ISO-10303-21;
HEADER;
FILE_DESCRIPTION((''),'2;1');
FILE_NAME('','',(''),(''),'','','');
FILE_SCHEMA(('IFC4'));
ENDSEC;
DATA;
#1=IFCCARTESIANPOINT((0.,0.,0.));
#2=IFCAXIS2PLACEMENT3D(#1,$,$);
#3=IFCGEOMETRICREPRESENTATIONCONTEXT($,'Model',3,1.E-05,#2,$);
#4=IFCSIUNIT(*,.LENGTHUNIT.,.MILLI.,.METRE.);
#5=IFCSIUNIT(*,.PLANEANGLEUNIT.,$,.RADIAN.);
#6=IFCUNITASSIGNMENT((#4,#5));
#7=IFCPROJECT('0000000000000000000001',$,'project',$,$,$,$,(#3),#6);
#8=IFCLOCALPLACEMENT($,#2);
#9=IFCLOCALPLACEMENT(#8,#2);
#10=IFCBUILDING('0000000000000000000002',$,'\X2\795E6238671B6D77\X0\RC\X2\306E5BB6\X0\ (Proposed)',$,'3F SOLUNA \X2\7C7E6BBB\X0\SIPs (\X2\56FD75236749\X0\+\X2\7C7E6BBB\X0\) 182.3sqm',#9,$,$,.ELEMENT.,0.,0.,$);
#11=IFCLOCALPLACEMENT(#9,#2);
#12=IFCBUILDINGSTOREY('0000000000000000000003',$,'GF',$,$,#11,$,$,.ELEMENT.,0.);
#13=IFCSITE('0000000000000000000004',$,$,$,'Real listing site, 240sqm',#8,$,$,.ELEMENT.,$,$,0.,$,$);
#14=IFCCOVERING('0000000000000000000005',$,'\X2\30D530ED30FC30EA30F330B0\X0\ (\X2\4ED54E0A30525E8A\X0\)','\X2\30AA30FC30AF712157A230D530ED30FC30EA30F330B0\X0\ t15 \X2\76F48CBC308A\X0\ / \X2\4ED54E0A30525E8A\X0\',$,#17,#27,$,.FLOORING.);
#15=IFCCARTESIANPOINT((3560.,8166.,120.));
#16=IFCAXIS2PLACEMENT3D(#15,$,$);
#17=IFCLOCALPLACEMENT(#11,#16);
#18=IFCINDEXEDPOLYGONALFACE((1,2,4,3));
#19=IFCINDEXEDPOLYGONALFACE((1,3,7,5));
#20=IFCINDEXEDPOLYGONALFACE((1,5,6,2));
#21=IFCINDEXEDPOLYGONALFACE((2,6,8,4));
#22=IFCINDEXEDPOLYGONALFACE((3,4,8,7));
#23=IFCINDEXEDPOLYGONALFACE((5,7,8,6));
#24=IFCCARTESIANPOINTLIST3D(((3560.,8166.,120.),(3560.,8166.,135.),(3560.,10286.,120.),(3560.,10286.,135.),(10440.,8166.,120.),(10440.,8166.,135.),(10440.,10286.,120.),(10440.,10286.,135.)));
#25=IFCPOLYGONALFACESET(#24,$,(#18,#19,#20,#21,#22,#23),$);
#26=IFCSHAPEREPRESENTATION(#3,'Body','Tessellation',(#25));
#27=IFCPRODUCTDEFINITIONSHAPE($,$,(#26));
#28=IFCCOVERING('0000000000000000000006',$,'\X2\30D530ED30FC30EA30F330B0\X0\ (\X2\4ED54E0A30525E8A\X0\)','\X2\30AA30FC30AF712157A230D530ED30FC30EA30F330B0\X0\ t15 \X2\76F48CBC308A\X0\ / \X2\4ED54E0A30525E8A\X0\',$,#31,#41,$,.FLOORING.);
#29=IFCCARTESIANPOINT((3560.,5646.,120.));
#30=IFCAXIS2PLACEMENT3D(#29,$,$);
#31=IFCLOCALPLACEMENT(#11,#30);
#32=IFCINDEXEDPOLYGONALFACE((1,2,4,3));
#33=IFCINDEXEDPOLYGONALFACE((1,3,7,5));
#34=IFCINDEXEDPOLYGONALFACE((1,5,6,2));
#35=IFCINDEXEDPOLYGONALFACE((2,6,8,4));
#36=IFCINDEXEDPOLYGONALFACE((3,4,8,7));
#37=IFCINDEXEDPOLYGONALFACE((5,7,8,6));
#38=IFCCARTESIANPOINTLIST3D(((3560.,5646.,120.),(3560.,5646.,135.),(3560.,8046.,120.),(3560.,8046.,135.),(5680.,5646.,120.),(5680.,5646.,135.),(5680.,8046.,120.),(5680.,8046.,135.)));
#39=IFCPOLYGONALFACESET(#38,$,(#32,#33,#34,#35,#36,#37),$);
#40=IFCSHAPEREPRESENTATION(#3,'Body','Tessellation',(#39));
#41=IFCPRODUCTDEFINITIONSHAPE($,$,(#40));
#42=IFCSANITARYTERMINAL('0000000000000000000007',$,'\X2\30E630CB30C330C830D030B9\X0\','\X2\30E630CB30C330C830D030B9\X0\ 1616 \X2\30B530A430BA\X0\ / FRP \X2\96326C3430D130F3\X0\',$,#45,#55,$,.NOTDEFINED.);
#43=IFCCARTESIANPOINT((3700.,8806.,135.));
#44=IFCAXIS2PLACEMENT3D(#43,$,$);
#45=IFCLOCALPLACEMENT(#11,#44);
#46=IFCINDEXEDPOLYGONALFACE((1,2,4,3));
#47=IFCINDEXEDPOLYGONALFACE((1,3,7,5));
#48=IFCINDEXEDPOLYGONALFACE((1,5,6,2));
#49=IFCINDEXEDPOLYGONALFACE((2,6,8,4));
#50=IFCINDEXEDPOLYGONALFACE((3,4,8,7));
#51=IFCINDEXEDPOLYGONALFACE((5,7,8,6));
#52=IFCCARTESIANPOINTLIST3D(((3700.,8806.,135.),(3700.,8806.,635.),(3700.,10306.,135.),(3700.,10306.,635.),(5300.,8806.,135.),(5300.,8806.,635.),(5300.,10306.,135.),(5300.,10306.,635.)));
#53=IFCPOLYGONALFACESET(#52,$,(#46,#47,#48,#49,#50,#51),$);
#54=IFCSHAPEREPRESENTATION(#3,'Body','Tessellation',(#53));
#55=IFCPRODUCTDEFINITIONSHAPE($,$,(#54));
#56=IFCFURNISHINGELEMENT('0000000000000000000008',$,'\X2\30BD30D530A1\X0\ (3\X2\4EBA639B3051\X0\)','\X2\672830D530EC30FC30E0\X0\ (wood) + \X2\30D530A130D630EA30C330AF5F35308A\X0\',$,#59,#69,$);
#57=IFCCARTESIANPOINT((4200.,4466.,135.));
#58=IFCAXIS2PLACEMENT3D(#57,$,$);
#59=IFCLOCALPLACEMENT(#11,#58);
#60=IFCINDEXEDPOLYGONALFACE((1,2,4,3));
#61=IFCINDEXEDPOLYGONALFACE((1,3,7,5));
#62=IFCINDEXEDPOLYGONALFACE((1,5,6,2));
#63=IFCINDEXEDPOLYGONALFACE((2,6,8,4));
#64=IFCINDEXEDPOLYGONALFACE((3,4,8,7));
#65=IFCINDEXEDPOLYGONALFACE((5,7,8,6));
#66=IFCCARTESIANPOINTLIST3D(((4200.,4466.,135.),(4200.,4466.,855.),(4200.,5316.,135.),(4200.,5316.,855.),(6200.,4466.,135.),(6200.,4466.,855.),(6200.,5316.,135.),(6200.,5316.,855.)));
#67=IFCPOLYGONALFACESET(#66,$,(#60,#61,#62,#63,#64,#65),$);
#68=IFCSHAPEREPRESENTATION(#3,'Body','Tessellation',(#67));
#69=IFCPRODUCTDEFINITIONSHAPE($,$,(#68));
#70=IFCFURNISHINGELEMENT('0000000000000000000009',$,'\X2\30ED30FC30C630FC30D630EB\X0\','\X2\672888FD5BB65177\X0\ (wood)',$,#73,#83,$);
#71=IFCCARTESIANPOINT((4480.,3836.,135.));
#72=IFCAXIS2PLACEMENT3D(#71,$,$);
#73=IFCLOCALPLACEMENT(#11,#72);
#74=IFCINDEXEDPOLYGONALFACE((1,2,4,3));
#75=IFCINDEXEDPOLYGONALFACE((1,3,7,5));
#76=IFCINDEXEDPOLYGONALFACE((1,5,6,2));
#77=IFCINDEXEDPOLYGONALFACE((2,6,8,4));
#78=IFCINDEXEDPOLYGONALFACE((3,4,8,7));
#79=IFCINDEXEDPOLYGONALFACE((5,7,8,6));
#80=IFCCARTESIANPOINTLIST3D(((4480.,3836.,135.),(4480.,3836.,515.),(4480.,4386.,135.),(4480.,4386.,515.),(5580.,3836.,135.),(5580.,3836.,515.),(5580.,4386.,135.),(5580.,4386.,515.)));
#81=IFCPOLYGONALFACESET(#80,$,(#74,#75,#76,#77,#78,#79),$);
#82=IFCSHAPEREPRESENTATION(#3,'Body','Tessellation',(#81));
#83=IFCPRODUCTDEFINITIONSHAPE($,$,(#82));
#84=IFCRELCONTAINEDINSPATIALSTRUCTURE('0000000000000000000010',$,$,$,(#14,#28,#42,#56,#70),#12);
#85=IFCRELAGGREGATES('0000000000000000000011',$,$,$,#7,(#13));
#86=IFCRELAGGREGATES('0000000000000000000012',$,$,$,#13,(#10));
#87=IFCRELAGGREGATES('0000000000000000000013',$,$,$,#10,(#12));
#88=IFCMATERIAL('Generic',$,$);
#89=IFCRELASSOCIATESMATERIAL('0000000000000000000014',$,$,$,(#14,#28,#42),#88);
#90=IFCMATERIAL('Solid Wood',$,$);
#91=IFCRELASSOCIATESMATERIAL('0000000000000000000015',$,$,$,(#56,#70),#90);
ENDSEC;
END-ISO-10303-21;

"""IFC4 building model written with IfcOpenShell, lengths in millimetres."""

from ifc_helpers import new_model, si_unit, frame, frame_2d, origin, place, context, project, spatial, rectangle, extrude, material, element, save


model = new_model("IFC4")

# Units and contexts
model_context = context("Model", 3, precision=1e-05, world=origin())
ifc_project = project(units=[si_unit("LENGTHUNIT", "METRE", prefix="MILLI"), si_unit("PLANEANGLEUNIT", "RADIAN")], contexts=[model_context])

# Site, building, storey
site_placement = place(None, origin())
site = spatial("IfcSite", under=ifc_project, at=site_placement, ObjectType="Real listing site, 240sqm", CompositionType="ELEMENT", RefElevation=0.0)
building_placement = place(site_placement, origin())
building = spatial("IfcBuilding", under=site, at=building_placement, Name="神戸望海RCの家 (Proposed)", ObjectType="3F SOLUNA 籾殻SIPs (国産杉+籾殻) 182.3sqm", CompositionType="ELEMENT", ElevationOfRefHeight=0.0, ElevationOfTerrain=0.0)
storey_placement = place(building_placement, origin())
storey = spatial("IfcBuildingStorey", under=building, at=storey_placement, Name="GF", CompositionType="ELEMENT", Elevation=0.0)

# Shared definitions
ifc_material_1 = material(Name="Solid Wood")

# Coverings
ifc_material_2 = material(Name="Generic")
covering_1_placement = place(storey_placement, frame((3560.0, 8166.0, 120.0)))
element("IfcCovering", 1, at=covering_1_placement, inside=storey, material=ifc_material_2, Name="フローリング (仕上げ床)", Description="オーク無垢フローリング t15 直貼り / 仕上げ床", PredefinedType="FLOORING", context=model_context, shape_type="SweptSolid", body=[
    extrude(rectangle(XDim=6880.0, YDim=2120.0, at=frame_2d((3440.0, 1060.0))), frame((3560.0, 8166.0, 120.0)), (0.0, 0.0, 1.0), 15.0),
])
covering_2_placement = place(storey_placement, frame((3560.0, 5646.0, 120.0)))
element("IfcCovering", 2, at=covering_2_placement, inside=storey, material=ifc_material_2, Name="フローリング (仕上げ床)", Description="オーク無垢フローリング t15 直貼り / 仕上げ床", PredefinedType="FLOORING", context=model_context, shape_type="SweptSolid", body=[
    extrude(rectangle(XDim=2120.0, YDim=2400.0, at=frame_2d((1060.0, 1200.0))), frame((3560.0, 5646.0, 120.0)), (0.0, 0.0, 1.0), 15.0),
])

# Sanitary terminal
sanitary_terminal_placement = place(storey_placement, frame((3700.0, 8806.0, 135.0)))
element("IfcSanitaryTerminal", 3, at=sanitary_terminal_placement, inside=storey, material=ifc_material_2, Name="ユニットバス", Description="ユニットバス 1616 サイズ / FRP 防水パン", PredefinedType="NOTDEFINED", context=model_context, shape_type="SweptSolid", body=[
    extrude(rectangle(XDim=1600.0, YDim=1500.0, at=frame_2d((800.0, 750.0))), frame((3700.0, 8806.0, 135.0)), (0.0, 0.0, 1.0), 500.0),
])

# Furnishing elements
furnishing_1_placement = place(storey_placement, frame((4200.0, 4466.0, 135.0)))
element("IfcFurnishingElement", 4, at=furnishing_1_placement, inside=storey, material=ifc_material_1, Name="ソファ (3人掛け)", Description="木フレーム (wood) + ファブリック張り", context=model_context, shape_type="SweptSolid", body=[
    extrude(rectangle(XDim=2000.0, YDim=850.0, at=frame_2d((1000.0, 425.0))), frame((4200.0, 4466.0, 135.0)), (0.0, 0.0, 1.0), 720.0),
])
furnishing_2_placement = place(storey_placement, frame((4480.0, 3836.0, 135.0)))
element("IfcFurnishingElement", 5, at=furnishing_2_placement, inside=storey, material=ifc_material_1, Name="ローテーブル", Description="木製家具 (wood)", context=model_context, shape_type="SweptSolid", body=[
    extrude(rectangle(XDim=1100.0, YDim=550.0, at=frame_2d((550.0, 275.0))), frame((4480.0, 3836.0, 135.0)), (0.0, 0.0, 1.0), 380.0),
])

save(model, "model.ifc")
